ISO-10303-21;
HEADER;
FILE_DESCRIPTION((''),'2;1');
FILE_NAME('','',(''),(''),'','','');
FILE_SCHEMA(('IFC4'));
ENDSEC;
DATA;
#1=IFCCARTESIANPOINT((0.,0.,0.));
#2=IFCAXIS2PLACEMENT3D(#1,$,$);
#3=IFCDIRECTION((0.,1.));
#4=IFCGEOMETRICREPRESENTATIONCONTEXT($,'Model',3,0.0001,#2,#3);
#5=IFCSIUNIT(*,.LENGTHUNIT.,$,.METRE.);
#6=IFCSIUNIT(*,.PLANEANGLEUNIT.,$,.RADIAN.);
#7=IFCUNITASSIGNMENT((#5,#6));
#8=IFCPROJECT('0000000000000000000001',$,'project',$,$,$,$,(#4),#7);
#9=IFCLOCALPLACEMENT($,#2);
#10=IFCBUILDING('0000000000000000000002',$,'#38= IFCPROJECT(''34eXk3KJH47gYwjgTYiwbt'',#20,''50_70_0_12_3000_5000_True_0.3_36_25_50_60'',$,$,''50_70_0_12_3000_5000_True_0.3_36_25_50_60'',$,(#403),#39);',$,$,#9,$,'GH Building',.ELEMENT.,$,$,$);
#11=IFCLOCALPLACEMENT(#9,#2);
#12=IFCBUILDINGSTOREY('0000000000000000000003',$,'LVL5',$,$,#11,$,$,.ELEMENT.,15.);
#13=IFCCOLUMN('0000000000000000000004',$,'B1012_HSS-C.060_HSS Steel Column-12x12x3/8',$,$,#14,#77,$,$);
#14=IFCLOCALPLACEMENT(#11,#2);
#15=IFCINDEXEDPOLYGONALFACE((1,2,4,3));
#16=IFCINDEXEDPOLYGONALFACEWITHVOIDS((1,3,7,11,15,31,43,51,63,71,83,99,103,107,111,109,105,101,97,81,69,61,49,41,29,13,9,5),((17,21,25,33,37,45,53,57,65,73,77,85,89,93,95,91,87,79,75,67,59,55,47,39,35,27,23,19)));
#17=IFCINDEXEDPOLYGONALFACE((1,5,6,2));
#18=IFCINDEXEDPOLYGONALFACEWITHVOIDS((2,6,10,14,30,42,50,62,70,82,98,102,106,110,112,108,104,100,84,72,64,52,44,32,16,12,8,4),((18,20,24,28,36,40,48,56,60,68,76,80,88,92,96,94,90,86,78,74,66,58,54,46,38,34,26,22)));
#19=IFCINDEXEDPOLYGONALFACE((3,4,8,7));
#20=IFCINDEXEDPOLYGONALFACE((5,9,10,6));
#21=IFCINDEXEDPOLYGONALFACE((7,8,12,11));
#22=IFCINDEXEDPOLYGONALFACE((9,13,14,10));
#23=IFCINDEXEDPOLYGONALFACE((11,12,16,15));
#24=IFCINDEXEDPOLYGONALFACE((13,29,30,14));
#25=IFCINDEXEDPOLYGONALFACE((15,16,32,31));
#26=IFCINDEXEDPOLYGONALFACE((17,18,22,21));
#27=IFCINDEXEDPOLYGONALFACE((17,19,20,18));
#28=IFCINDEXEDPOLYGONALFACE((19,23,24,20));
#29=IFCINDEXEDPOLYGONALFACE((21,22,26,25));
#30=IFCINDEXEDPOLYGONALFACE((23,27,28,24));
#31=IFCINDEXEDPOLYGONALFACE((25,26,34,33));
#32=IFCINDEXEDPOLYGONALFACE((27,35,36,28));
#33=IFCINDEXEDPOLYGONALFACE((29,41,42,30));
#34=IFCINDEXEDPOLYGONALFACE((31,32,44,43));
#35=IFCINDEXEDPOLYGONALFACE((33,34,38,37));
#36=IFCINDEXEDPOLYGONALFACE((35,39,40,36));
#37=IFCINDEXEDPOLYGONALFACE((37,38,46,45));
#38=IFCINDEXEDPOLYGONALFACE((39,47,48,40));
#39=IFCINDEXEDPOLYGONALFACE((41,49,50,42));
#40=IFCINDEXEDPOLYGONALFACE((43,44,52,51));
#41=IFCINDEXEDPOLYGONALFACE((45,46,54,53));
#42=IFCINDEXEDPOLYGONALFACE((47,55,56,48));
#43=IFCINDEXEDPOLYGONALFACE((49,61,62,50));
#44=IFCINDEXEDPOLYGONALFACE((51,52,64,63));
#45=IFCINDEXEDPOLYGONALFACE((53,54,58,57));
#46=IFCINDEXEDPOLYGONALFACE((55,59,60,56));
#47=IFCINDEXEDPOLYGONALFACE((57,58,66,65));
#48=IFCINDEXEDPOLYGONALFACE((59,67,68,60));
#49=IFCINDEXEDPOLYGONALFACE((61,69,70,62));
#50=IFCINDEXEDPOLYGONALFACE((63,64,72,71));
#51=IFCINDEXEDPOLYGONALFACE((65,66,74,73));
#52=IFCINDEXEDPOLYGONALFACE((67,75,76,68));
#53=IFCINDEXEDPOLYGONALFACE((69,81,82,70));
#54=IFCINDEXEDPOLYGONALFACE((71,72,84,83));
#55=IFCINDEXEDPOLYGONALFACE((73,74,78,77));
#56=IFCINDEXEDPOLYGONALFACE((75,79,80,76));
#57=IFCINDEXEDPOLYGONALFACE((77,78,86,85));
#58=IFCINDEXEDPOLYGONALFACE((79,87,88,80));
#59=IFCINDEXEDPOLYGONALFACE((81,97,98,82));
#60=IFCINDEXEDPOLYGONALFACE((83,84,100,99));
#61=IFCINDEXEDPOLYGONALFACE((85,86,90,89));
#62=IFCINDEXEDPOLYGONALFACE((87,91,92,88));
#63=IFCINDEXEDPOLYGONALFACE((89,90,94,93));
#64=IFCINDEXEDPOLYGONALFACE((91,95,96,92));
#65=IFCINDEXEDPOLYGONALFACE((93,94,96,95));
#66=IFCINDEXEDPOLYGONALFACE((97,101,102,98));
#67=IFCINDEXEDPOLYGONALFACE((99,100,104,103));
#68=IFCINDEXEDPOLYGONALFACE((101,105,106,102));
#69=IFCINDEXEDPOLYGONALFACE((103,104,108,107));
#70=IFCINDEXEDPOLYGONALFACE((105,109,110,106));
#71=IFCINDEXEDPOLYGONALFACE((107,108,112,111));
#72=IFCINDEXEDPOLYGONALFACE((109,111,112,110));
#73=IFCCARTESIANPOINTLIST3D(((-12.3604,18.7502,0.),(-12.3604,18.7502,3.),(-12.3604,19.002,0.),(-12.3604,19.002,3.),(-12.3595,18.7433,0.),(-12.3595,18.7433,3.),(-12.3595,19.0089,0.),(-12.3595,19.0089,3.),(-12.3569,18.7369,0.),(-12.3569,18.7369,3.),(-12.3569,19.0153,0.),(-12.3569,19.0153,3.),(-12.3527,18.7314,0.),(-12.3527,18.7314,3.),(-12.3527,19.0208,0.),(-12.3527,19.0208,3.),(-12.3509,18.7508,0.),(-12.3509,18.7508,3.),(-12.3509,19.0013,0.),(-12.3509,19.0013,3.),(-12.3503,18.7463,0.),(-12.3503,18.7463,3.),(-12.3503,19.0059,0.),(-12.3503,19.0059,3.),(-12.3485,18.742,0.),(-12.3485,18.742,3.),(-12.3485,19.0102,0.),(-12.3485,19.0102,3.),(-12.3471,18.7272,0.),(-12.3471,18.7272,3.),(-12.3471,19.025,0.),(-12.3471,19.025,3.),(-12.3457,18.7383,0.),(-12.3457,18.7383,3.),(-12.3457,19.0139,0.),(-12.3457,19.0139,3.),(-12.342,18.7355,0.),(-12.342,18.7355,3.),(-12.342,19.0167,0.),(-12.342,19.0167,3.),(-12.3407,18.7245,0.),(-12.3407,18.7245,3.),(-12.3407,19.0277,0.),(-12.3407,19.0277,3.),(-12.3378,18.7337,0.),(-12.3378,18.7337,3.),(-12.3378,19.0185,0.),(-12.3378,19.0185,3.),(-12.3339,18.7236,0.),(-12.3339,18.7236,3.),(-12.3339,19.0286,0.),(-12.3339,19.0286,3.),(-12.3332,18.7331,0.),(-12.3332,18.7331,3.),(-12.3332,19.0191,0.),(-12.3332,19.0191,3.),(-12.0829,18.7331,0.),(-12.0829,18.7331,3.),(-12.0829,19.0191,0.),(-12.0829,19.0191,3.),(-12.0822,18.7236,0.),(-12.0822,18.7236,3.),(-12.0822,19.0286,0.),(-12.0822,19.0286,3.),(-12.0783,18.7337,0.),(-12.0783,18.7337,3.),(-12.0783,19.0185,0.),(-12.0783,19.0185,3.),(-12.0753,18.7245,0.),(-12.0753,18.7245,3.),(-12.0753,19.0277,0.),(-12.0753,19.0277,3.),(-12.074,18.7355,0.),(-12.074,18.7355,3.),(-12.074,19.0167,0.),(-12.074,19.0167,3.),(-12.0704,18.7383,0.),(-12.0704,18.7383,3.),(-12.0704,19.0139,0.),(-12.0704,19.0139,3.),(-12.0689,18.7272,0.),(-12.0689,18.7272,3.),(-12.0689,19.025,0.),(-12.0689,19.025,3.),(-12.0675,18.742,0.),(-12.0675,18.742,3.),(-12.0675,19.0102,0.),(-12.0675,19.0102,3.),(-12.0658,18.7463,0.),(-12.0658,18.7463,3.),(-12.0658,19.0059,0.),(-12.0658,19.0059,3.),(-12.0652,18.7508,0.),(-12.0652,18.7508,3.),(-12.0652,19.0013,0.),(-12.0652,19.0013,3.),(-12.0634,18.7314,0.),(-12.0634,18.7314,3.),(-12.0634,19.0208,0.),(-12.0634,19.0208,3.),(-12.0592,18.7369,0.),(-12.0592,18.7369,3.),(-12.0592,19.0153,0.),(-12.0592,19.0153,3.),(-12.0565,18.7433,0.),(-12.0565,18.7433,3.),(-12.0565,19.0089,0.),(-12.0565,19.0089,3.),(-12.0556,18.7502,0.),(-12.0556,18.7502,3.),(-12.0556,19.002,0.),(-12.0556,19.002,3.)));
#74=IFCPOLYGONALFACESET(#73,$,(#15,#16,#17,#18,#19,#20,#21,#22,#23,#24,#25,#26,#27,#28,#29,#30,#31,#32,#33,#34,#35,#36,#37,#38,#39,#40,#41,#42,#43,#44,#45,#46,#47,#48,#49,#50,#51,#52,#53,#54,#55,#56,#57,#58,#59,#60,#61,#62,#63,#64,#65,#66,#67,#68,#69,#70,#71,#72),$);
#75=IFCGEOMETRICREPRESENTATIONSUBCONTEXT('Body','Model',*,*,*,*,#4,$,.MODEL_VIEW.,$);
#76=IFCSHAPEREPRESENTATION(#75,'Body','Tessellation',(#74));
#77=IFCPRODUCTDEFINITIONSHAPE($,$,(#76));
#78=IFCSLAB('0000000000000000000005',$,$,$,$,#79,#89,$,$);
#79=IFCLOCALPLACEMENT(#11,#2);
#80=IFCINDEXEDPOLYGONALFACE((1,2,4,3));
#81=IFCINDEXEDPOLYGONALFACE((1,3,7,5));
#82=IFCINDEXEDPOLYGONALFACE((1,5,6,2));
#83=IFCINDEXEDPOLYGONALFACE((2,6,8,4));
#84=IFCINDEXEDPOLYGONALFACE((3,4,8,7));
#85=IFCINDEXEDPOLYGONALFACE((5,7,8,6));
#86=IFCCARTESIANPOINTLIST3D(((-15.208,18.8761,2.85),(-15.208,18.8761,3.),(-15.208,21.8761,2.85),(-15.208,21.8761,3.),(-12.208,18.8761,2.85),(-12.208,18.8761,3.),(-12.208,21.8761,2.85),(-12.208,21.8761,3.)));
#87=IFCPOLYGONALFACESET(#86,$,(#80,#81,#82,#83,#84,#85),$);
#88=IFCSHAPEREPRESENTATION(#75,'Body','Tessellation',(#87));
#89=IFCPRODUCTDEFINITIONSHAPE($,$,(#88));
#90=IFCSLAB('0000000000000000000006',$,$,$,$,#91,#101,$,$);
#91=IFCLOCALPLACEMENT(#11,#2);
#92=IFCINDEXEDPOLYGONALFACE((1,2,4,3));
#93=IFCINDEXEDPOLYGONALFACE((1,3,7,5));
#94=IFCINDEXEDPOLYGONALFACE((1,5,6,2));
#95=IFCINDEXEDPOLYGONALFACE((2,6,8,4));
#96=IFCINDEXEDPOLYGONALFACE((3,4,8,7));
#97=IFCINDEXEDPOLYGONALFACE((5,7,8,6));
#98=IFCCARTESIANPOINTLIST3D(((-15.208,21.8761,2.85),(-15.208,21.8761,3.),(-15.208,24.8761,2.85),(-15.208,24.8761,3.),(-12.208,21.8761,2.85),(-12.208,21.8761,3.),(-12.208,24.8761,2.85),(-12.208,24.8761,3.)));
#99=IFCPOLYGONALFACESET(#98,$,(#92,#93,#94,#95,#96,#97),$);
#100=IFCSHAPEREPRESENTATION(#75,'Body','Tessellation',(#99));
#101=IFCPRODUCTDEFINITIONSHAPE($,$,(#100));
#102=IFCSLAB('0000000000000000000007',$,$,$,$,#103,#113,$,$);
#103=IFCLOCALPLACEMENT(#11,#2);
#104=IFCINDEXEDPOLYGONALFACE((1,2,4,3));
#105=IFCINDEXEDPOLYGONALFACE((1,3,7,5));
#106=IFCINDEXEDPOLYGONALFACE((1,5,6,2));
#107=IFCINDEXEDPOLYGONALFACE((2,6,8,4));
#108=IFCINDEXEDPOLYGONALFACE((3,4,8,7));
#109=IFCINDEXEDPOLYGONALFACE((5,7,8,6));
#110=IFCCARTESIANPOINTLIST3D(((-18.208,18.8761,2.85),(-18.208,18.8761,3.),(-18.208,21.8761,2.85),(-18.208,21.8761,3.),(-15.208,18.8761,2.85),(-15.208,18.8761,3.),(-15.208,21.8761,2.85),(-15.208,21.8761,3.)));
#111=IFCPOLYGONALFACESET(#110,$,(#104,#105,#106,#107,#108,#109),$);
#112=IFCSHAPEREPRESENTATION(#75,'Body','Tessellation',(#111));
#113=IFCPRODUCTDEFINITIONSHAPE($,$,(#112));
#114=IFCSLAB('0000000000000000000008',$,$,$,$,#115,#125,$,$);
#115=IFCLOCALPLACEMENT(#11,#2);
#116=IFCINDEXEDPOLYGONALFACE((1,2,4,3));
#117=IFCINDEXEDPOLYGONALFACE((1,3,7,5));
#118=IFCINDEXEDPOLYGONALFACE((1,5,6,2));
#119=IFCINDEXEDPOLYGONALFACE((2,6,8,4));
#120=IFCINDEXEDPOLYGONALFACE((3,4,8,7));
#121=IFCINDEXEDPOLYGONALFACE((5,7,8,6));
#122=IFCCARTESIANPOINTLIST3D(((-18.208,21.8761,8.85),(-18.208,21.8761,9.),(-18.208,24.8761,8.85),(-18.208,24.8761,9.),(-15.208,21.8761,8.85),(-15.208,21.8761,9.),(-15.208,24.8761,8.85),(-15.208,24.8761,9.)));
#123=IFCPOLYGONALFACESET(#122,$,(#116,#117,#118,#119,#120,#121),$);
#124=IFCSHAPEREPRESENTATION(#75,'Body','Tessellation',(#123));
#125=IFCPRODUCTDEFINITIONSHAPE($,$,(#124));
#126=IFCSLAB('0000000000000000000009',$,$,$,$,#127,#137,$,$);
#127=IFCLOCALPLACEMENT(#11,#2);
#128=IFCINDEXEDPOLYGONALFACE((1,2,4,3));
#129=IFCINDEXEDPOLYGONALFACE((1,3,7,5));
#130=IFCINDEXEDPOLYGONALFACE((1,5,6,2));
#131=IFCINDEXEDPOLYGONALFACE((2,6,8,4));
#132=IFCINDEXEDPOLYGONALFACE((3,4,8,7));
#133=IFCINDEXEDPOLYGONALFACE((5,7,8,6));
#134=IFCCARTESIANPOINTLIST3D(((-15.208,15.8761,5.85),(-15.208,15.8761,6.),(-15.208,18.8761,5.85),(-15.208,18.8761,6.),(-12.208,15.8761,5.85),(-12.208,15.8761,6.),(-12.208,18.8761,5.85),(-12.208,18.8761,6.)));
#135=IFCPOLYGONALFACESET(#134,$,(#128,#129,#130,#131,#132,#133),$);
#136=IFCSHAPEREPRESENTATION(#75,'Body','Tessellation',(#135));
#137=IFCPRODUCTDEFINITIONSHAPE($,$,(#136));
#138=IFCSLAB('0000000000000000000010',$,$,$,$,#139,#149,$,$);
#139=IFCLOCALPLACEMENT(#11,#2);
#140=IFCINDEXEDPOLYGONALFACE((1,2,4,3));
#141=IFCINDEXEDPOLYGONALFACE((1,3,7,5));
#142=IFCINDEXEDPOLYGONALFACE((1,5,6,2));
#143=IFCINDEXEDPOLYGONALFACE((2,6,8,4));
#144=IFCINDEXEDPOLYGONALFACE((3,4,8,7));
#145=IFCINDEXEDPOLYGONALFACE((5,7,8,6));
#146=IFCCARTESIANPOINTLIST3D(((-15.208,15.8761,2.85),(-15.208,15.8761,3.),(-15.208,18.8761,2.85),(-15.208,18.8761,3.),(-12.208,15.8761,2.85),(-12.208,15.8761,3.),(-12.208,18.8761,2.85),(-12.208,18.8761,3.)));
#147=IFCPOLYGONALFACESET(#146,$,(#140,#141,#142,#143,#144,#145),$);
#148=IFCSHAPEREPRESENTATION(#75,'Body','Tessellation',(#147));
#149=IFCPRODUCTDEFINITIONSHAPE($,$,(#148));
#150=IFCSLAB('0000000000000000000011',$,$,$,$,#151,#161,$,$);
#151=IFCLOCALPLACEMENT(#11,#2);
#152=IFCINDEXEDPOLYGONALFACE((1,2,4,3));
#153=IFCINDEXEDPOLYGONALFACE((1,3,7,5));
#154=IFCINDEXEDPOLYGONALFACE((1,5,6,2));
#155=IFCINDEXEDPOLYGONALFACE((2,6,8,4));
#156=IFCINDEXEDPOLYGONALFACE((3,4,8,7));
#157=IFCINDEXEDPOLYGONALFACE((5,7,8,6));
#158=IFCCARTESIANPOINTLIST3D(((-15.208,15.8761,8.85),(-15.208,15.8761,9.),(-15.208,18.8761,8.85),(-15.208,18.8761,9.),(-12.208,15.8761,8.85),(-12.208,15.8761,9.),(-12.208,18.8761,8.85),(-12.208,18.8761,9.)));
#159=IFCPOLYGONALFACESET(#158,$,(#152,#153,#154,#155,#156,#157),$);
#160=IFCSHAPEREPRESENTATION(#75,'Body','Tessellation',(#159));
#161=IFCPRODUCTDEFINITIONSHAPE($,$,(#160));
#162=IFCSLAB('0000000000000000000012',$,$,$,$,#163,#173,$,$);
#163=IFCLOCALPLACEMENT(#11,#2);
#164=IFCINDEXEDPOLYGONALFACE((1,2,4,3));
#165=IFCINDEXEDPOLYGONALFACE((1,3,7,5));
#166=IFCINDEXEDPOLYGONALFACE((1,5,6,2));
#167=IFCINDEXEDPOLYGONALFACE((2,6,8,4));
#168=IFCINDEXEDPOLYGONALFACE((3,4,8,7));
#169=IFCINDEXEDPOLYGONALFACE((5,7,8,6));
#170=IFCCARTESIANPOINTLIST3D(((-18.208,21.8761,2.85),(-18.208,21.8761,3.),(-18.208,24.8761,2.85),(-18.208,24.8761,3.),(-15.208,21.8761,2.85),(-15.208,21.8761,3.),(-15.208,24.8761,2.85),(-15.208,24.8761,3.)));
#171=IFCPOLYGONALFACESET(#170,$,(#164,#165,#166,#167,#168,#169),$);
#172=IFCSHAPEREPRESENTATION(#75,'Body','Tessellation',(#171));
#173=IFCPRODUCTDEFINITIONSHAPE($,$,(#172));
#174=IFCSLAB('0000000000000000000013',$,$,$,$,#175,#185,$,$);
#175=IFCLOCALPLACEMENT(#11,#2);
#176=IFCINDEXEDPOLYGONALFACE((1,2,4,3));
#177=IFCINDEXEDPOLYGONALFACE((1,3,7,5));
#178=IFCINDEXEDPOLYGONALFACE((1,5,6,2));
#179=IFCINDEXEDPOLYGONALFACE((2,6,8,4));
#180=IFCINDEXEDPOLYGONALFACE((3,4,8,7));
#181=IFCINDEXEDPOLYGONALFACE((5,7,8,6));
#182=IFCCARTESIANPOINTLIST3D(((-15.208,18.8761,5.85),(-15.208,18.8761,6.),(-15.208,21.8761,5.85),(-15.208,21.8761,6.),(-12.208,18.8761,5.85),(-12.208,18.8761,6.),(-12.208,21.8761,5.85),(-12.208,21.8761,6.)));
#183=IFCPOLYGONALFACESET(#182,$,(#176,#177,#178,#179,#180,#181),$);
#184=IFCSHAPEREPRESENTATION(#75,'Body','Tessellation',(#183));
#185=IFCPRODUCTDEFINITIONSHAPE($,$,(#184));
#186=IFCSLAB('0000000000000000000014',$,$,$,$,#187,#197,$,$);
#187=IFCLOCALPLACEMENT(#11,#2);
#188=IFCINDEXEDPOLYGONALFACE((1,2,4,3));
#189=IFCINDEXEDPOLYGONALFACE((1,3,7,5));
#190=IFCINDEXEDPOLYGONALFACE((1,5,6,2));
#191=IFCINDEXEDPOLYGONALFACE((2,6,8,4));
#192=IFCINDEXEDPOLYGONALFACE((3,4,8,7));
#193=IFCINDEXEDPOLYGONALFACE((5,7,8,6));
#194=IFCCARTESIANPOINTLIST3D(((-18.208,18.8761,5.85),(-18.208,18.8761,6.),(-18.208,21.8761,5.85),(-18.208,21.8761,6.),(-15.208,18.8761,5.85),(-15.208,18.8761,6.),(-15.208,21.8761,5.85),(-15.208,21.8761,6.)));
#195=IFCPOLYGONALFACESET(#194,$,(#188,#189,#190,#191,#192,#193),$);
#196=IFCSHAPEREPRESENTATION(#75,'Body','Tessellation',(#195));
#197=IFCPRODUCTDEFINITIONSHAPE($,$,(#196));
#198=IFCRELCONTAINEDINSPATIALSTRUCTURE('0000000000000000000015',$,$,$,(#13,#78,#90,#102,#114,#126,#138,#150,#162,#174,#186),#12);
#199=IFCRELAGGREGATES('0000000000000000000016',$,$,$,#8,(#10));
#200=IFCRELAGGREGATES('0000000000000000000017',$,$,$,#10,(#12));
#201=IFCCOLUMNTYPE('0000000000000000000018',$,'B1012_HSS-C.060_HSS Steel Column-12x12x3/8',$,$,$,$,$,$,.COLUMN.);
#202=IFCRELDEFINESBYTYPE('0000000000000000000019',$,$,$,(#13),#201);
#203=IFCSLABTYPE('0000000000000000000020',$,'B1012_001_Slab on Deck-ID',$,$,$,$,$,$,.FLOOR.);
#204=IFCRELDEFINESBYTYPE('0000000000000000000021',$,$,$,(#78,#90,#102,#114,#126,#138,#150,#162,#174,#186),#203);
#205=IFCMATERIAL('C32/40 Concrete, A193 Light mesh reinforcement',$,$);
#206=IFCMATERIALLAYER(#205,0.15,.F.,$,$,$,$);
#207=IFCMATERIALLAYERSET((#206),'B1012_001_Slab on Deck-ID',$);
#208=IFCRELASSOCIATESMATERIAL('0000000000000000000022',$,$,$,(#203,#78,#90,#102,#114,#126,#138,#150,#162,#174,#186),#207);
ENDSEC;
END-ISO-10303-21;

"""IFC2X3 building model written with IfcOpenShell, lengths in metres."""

from ifc_helpers import new_model, si_unit, direction, frame, origin, origin_2d, place, context, subcontext, project, spatial, polyline, hollow_rectangle, outline, extrude, material, layer, layer_set, layer_usage, type_object, element, save


model = new_model("IFC2X3")

# Units and contexts
model_context = context("Model", 3, precision=0.0001, world=origin(), true_north=direction((0.0, 1.0)))
body_context = subcontext(model_context, "Body", "Model", "MODEL_VIEW")
ifc_project = project(units=[si_unit("LENGTHUNIT", "METRE"), si_unit("PLANEANGLEUNIT", "RADIAN")], contexts=[model_context])

# Building, storey
building_placement = place(None, origin())
building = spatial("IfcBuilding", under=ifc_project, at=building_placement, Name="#38= IFCPROJECT('34eXk3KJH47gYwjgTYiwbt',#20,'50_70_0_12_3000_5000_True_0.3_36_25_50_60',$,$,'50_70_0_12_3000_5000_True_0.3_36_25_50_60',$,(#403),#39);", LongName="GH Building", CompositionType="ELEMENT")
storey_placement = place(building_placement, origin())
storey = spatial("IfcBuildingStorey", under=building, at=storey_placement, Name="LVL5", CompositionType="ELEMENT", Elevation=15.0)

# Column
column_type = type_object("IfcColumnType", Name="B1012_HSS-C.060_HSS Steel Column-12x12x3/8", PredefinedType="COLUMN")
column_placement = place(storey_placement, frame((-12.208, 18.8761, 3.0), z_axis=(0.0, 0.0, -1.0), x_axis=(-1.0, 0.0, 0.0)))
element("IfcColumn", 1, at=column_placement, inside=storey, type_object=column_type, Name="B1012_HSS-C.060_HSS Steel Column-12x12x3/8", context=body_context, shape_type="SweptSolid", body=[
    extrude(hollow_rectangle(XDim=0.3048, YDim=0.305, WallThickness=0.0095, InnerFilletRadius=0.0177, OuterFilletRadius=0.0266, at=origin_2d()), origin(), (0.0, 0.0, 1.0), 3.0),
])

# Slabs
ifc_material_1 = material(Name="C32/40 Concrete, A193 Light mesh reinforcement")
ifc_layer_1 = layer(ifc_material_1, 0.15, ventilated=False)
ifc_layer_set_1 = layer_set([ifc_layer_1], Name="B1012_001_Slab on Deck-ID")
ifc_layer_usage_1 = layer_usage(ifc_layer_set_1, "AXIS3", "NEGATIVE", -0.15)
slab_type_1 = type_object("IfcSlabType", Name="B1012_001_Slab on Deck-ID", PredefinedType="FLOOR", material=ifc_layer_set_1)
slab_1_placement = place(storey_placement, frame((-13.708, 20.3761, 2.85), z_axis=(0.0, 0.0, 1.0), x_axis=(0.0, 1.0, 0.0)))
element("IfcSlab", 2, at=slab_1_placement, inside=storey, type_object=slab_type_1, material=ifc_layer_usage_1, context=body_context, shape_type="SweptSolid", body=[
    extrude(outline(polyline([(-1.5, -1.5), (1.5, -1.5), (1.5, 1.5), (-1.5, 1.5), (-1.5, -1.5)])), origin(), (0.0, 0.0, 1.0), 0.15),
])
ifc_layer_usage_2 = layer_usage(ifc_layer_set_1, "AXIS3", "NEGATIVE", -0.15)
slab_2_placement = place(storey_placement, frame((-13.708, 23.3761, 2.85), z_axis=(0.0, 0.0, 1.0), x_axis=(0.0, 1.0, 0.0)))
element("IfcSlab", 3, at=slab_2_placement, inside=storey, type_object=slab_type_1, material=ifc_layer_usage_2, context=body_context, shape_type="SweptSolid", body=[
    extrude(outline(polyline([(1.5, -1.5), (1.5, 1.5), (-1.5, 1.5), (-1.5, -1.5), (1.5, -1.5)])), origin(), (0.0, 0.0, 1.0), 0.15),
])
ifc_layer_usage_3 = layer_usage(ifc_layer_set_1, "AXIS3", "NEGATIVE", -0.15)
slab_3_placement = place(storey_placement, frame((-16.708, 20.3761, 2.85), z_axis=(0.0, 0.0, 1.0), x_axis=(0.0, 1.0, 0.0)))
element("IfcSlab", 4, at=slab_3_placement, inside=storey, type_object=slab_type_1, material=ifc_layer_usage_3, context=body_context, shape_type="SweptSolid", body=[
    extrude(outline(polyline([(-1.5, -1.5), (1.5, -1.5), (1.5, 1.5), (-1.5, 1.5), (-1.5, -1.5)])), origin(), (0.0, 0.0, 1.0), 0.15),
])
ifc_layer_usage_4 = layer_usage(ifc_layer_set_1, "AXIS3", "NEGATIVE", -0.15)
slab_4_placement = place(storey_placement, frame((-16.708, 23.3761, 8.85)))
element("IfcSlab", 5, at=slab_4_placement, inside=storey, type_object=slab_type_1, material=ifc_layer_usage_4, context=body_context, shape_type="SweptSolid", body=[
    extrude(outline(polyline([(1.5, -1.5), (-1.5, -1.5), (-1.5, 1.5), (1.5, 1.5), (1.5, -1.5)])), origin(), (0.0, 0.0, 1.0), 0.15),
])
ifc_layer_usage_5 = layer_usage(ifc_layer_set_1, "AXIS3", "NEGATIVE", -0.15)
slab_5_placement = place(storey_placement, frame((-13.708, 17.3761, 5.85)))
element("IfcSlab", 6, at=slab_5_placement, inside=storey, type_object=slab_type_1, material=ifc_layer_usage_5, context=body_context, shape_type="SweptSolid", body=[
    extrude(outline(polyline([(1.5, -1.5), (-1.5, -1.5), (-1.5, 1.5), (1.5, 1.5), (1.5, -1.5)])), origin(), (0.0, 0.0, 1.0), 0.15),
])
ifc_layer_usage_6 = layer_usage(ifc_layer_set_1, "AXIS3", "NEGATIVE", -0.15)
slab_6_placement = place(storey_placement, frame((-13.708, 17.3761, 2.85)))
element("IfcSlab", 7, at=slab_6_placement, inside=storey, type_object=slab_type_1, material=ifc_layer_usage_6, context=body_context, shape_type="SweptSolid", body=[
    extrude(outline(polyline([(1.5, -1.5), (-1.5, -1.5), (-1.5, 1.5), (1.5, 1.5), (1.5, -1.5)])), origin(), (0.0, 0.0, 1.0), 0.15),
])
ifc_layer_usage_7 = layer_usage(ifc_layer_set_1, "AXIS3", "NEGATIVE", -0.15)
slab_7_placement = place(storey_placement, frame((-13.708, 17.3761, 8.85)))
element("IfcSlab", 8, at=slab_7_placement, inside=storey, type_object=slab_type_1, material=ifc_layer_usage_7, context=body_context, shape_type="SweptSolid", body=[
    extrude(outline(polyline([(1.5, -1.5), (-1.5, -1.5), (-1.5, 1.5), (1.5, 1.5), (1.5, -1.5)])), origin(), (0.0, 0.0, 1.0), 0.15),
])
ifc_layer_usage_8 = layer_usage(ifc_layer_set_1, "AXIS3", "NEGATIVE", -0.15)
slab_8_placement = place(storey_placement, frame((-16.708, 23.3761, 2.85), z_axis=(0.0, 0.0, 1.0), x_axis=(0.0, 1.0, 0.0)))
element("IfcSlab", 9, at=slab_8_placement, inside=storey, type_object=slab_type_1, material=ifc_layer_usage_8, context=body_context, shape_type="SweptSolid", body=[
    extrude(outline(polyline([(1.5, -1.5), (1.5, 1.5), (-1.5, 1.5), (-1.5, -1.5), (1.5, -1.5)])), origin(), (0.0, 0.0, 1.0), 0.15),
])
ifc_layer_usage_9 = layer_usage(ifc_layer_set_1, "AXIS3", "NEGATIVE", -0.15)
slab_9_placement = place(storey_placement, frame((-13.708, 20.3761, 5.85)))
element("IfcSlab", 10, at=slab_9_placement, inside=storey, type_object=slab_type_1, material=ifc_layer_usage_9, context=body_context, shape_type="SweptSolid", body=[
    extrude(outline(polyline([(-1.5, -1.5), (-1.5, 1.5), (1.5, 1.5), (1.5, -1.5), (-1.5, -1.5)])), origin(), (0.0, 0.0, 1.0), 0.15),
])
ifc_layer_usage_10 = layer_usage(ifc_layer_set_1, "AXIS3", "NEGATIVE", -0.15)
slab_10_placement = place(storey_placement, frame((-16.708, 20.3761, 5.85)))
element("IfcSlab", 11, at=slab_10_placement, inside=storey, type_object=slab_type_1, material=ifc_layer_usage_10, context=body_context, shape_type="SweptSolid", body=[
    extrude(outline(polyline([(1.5, -1.5), (-1.5, -1.5), (-1.5, 1.5), (1.5, 1.5), (1.5, -1.5)])), origin(), (0.0, 0.0, 1.0), 0.15),
])

save(model, "model.ifc")
